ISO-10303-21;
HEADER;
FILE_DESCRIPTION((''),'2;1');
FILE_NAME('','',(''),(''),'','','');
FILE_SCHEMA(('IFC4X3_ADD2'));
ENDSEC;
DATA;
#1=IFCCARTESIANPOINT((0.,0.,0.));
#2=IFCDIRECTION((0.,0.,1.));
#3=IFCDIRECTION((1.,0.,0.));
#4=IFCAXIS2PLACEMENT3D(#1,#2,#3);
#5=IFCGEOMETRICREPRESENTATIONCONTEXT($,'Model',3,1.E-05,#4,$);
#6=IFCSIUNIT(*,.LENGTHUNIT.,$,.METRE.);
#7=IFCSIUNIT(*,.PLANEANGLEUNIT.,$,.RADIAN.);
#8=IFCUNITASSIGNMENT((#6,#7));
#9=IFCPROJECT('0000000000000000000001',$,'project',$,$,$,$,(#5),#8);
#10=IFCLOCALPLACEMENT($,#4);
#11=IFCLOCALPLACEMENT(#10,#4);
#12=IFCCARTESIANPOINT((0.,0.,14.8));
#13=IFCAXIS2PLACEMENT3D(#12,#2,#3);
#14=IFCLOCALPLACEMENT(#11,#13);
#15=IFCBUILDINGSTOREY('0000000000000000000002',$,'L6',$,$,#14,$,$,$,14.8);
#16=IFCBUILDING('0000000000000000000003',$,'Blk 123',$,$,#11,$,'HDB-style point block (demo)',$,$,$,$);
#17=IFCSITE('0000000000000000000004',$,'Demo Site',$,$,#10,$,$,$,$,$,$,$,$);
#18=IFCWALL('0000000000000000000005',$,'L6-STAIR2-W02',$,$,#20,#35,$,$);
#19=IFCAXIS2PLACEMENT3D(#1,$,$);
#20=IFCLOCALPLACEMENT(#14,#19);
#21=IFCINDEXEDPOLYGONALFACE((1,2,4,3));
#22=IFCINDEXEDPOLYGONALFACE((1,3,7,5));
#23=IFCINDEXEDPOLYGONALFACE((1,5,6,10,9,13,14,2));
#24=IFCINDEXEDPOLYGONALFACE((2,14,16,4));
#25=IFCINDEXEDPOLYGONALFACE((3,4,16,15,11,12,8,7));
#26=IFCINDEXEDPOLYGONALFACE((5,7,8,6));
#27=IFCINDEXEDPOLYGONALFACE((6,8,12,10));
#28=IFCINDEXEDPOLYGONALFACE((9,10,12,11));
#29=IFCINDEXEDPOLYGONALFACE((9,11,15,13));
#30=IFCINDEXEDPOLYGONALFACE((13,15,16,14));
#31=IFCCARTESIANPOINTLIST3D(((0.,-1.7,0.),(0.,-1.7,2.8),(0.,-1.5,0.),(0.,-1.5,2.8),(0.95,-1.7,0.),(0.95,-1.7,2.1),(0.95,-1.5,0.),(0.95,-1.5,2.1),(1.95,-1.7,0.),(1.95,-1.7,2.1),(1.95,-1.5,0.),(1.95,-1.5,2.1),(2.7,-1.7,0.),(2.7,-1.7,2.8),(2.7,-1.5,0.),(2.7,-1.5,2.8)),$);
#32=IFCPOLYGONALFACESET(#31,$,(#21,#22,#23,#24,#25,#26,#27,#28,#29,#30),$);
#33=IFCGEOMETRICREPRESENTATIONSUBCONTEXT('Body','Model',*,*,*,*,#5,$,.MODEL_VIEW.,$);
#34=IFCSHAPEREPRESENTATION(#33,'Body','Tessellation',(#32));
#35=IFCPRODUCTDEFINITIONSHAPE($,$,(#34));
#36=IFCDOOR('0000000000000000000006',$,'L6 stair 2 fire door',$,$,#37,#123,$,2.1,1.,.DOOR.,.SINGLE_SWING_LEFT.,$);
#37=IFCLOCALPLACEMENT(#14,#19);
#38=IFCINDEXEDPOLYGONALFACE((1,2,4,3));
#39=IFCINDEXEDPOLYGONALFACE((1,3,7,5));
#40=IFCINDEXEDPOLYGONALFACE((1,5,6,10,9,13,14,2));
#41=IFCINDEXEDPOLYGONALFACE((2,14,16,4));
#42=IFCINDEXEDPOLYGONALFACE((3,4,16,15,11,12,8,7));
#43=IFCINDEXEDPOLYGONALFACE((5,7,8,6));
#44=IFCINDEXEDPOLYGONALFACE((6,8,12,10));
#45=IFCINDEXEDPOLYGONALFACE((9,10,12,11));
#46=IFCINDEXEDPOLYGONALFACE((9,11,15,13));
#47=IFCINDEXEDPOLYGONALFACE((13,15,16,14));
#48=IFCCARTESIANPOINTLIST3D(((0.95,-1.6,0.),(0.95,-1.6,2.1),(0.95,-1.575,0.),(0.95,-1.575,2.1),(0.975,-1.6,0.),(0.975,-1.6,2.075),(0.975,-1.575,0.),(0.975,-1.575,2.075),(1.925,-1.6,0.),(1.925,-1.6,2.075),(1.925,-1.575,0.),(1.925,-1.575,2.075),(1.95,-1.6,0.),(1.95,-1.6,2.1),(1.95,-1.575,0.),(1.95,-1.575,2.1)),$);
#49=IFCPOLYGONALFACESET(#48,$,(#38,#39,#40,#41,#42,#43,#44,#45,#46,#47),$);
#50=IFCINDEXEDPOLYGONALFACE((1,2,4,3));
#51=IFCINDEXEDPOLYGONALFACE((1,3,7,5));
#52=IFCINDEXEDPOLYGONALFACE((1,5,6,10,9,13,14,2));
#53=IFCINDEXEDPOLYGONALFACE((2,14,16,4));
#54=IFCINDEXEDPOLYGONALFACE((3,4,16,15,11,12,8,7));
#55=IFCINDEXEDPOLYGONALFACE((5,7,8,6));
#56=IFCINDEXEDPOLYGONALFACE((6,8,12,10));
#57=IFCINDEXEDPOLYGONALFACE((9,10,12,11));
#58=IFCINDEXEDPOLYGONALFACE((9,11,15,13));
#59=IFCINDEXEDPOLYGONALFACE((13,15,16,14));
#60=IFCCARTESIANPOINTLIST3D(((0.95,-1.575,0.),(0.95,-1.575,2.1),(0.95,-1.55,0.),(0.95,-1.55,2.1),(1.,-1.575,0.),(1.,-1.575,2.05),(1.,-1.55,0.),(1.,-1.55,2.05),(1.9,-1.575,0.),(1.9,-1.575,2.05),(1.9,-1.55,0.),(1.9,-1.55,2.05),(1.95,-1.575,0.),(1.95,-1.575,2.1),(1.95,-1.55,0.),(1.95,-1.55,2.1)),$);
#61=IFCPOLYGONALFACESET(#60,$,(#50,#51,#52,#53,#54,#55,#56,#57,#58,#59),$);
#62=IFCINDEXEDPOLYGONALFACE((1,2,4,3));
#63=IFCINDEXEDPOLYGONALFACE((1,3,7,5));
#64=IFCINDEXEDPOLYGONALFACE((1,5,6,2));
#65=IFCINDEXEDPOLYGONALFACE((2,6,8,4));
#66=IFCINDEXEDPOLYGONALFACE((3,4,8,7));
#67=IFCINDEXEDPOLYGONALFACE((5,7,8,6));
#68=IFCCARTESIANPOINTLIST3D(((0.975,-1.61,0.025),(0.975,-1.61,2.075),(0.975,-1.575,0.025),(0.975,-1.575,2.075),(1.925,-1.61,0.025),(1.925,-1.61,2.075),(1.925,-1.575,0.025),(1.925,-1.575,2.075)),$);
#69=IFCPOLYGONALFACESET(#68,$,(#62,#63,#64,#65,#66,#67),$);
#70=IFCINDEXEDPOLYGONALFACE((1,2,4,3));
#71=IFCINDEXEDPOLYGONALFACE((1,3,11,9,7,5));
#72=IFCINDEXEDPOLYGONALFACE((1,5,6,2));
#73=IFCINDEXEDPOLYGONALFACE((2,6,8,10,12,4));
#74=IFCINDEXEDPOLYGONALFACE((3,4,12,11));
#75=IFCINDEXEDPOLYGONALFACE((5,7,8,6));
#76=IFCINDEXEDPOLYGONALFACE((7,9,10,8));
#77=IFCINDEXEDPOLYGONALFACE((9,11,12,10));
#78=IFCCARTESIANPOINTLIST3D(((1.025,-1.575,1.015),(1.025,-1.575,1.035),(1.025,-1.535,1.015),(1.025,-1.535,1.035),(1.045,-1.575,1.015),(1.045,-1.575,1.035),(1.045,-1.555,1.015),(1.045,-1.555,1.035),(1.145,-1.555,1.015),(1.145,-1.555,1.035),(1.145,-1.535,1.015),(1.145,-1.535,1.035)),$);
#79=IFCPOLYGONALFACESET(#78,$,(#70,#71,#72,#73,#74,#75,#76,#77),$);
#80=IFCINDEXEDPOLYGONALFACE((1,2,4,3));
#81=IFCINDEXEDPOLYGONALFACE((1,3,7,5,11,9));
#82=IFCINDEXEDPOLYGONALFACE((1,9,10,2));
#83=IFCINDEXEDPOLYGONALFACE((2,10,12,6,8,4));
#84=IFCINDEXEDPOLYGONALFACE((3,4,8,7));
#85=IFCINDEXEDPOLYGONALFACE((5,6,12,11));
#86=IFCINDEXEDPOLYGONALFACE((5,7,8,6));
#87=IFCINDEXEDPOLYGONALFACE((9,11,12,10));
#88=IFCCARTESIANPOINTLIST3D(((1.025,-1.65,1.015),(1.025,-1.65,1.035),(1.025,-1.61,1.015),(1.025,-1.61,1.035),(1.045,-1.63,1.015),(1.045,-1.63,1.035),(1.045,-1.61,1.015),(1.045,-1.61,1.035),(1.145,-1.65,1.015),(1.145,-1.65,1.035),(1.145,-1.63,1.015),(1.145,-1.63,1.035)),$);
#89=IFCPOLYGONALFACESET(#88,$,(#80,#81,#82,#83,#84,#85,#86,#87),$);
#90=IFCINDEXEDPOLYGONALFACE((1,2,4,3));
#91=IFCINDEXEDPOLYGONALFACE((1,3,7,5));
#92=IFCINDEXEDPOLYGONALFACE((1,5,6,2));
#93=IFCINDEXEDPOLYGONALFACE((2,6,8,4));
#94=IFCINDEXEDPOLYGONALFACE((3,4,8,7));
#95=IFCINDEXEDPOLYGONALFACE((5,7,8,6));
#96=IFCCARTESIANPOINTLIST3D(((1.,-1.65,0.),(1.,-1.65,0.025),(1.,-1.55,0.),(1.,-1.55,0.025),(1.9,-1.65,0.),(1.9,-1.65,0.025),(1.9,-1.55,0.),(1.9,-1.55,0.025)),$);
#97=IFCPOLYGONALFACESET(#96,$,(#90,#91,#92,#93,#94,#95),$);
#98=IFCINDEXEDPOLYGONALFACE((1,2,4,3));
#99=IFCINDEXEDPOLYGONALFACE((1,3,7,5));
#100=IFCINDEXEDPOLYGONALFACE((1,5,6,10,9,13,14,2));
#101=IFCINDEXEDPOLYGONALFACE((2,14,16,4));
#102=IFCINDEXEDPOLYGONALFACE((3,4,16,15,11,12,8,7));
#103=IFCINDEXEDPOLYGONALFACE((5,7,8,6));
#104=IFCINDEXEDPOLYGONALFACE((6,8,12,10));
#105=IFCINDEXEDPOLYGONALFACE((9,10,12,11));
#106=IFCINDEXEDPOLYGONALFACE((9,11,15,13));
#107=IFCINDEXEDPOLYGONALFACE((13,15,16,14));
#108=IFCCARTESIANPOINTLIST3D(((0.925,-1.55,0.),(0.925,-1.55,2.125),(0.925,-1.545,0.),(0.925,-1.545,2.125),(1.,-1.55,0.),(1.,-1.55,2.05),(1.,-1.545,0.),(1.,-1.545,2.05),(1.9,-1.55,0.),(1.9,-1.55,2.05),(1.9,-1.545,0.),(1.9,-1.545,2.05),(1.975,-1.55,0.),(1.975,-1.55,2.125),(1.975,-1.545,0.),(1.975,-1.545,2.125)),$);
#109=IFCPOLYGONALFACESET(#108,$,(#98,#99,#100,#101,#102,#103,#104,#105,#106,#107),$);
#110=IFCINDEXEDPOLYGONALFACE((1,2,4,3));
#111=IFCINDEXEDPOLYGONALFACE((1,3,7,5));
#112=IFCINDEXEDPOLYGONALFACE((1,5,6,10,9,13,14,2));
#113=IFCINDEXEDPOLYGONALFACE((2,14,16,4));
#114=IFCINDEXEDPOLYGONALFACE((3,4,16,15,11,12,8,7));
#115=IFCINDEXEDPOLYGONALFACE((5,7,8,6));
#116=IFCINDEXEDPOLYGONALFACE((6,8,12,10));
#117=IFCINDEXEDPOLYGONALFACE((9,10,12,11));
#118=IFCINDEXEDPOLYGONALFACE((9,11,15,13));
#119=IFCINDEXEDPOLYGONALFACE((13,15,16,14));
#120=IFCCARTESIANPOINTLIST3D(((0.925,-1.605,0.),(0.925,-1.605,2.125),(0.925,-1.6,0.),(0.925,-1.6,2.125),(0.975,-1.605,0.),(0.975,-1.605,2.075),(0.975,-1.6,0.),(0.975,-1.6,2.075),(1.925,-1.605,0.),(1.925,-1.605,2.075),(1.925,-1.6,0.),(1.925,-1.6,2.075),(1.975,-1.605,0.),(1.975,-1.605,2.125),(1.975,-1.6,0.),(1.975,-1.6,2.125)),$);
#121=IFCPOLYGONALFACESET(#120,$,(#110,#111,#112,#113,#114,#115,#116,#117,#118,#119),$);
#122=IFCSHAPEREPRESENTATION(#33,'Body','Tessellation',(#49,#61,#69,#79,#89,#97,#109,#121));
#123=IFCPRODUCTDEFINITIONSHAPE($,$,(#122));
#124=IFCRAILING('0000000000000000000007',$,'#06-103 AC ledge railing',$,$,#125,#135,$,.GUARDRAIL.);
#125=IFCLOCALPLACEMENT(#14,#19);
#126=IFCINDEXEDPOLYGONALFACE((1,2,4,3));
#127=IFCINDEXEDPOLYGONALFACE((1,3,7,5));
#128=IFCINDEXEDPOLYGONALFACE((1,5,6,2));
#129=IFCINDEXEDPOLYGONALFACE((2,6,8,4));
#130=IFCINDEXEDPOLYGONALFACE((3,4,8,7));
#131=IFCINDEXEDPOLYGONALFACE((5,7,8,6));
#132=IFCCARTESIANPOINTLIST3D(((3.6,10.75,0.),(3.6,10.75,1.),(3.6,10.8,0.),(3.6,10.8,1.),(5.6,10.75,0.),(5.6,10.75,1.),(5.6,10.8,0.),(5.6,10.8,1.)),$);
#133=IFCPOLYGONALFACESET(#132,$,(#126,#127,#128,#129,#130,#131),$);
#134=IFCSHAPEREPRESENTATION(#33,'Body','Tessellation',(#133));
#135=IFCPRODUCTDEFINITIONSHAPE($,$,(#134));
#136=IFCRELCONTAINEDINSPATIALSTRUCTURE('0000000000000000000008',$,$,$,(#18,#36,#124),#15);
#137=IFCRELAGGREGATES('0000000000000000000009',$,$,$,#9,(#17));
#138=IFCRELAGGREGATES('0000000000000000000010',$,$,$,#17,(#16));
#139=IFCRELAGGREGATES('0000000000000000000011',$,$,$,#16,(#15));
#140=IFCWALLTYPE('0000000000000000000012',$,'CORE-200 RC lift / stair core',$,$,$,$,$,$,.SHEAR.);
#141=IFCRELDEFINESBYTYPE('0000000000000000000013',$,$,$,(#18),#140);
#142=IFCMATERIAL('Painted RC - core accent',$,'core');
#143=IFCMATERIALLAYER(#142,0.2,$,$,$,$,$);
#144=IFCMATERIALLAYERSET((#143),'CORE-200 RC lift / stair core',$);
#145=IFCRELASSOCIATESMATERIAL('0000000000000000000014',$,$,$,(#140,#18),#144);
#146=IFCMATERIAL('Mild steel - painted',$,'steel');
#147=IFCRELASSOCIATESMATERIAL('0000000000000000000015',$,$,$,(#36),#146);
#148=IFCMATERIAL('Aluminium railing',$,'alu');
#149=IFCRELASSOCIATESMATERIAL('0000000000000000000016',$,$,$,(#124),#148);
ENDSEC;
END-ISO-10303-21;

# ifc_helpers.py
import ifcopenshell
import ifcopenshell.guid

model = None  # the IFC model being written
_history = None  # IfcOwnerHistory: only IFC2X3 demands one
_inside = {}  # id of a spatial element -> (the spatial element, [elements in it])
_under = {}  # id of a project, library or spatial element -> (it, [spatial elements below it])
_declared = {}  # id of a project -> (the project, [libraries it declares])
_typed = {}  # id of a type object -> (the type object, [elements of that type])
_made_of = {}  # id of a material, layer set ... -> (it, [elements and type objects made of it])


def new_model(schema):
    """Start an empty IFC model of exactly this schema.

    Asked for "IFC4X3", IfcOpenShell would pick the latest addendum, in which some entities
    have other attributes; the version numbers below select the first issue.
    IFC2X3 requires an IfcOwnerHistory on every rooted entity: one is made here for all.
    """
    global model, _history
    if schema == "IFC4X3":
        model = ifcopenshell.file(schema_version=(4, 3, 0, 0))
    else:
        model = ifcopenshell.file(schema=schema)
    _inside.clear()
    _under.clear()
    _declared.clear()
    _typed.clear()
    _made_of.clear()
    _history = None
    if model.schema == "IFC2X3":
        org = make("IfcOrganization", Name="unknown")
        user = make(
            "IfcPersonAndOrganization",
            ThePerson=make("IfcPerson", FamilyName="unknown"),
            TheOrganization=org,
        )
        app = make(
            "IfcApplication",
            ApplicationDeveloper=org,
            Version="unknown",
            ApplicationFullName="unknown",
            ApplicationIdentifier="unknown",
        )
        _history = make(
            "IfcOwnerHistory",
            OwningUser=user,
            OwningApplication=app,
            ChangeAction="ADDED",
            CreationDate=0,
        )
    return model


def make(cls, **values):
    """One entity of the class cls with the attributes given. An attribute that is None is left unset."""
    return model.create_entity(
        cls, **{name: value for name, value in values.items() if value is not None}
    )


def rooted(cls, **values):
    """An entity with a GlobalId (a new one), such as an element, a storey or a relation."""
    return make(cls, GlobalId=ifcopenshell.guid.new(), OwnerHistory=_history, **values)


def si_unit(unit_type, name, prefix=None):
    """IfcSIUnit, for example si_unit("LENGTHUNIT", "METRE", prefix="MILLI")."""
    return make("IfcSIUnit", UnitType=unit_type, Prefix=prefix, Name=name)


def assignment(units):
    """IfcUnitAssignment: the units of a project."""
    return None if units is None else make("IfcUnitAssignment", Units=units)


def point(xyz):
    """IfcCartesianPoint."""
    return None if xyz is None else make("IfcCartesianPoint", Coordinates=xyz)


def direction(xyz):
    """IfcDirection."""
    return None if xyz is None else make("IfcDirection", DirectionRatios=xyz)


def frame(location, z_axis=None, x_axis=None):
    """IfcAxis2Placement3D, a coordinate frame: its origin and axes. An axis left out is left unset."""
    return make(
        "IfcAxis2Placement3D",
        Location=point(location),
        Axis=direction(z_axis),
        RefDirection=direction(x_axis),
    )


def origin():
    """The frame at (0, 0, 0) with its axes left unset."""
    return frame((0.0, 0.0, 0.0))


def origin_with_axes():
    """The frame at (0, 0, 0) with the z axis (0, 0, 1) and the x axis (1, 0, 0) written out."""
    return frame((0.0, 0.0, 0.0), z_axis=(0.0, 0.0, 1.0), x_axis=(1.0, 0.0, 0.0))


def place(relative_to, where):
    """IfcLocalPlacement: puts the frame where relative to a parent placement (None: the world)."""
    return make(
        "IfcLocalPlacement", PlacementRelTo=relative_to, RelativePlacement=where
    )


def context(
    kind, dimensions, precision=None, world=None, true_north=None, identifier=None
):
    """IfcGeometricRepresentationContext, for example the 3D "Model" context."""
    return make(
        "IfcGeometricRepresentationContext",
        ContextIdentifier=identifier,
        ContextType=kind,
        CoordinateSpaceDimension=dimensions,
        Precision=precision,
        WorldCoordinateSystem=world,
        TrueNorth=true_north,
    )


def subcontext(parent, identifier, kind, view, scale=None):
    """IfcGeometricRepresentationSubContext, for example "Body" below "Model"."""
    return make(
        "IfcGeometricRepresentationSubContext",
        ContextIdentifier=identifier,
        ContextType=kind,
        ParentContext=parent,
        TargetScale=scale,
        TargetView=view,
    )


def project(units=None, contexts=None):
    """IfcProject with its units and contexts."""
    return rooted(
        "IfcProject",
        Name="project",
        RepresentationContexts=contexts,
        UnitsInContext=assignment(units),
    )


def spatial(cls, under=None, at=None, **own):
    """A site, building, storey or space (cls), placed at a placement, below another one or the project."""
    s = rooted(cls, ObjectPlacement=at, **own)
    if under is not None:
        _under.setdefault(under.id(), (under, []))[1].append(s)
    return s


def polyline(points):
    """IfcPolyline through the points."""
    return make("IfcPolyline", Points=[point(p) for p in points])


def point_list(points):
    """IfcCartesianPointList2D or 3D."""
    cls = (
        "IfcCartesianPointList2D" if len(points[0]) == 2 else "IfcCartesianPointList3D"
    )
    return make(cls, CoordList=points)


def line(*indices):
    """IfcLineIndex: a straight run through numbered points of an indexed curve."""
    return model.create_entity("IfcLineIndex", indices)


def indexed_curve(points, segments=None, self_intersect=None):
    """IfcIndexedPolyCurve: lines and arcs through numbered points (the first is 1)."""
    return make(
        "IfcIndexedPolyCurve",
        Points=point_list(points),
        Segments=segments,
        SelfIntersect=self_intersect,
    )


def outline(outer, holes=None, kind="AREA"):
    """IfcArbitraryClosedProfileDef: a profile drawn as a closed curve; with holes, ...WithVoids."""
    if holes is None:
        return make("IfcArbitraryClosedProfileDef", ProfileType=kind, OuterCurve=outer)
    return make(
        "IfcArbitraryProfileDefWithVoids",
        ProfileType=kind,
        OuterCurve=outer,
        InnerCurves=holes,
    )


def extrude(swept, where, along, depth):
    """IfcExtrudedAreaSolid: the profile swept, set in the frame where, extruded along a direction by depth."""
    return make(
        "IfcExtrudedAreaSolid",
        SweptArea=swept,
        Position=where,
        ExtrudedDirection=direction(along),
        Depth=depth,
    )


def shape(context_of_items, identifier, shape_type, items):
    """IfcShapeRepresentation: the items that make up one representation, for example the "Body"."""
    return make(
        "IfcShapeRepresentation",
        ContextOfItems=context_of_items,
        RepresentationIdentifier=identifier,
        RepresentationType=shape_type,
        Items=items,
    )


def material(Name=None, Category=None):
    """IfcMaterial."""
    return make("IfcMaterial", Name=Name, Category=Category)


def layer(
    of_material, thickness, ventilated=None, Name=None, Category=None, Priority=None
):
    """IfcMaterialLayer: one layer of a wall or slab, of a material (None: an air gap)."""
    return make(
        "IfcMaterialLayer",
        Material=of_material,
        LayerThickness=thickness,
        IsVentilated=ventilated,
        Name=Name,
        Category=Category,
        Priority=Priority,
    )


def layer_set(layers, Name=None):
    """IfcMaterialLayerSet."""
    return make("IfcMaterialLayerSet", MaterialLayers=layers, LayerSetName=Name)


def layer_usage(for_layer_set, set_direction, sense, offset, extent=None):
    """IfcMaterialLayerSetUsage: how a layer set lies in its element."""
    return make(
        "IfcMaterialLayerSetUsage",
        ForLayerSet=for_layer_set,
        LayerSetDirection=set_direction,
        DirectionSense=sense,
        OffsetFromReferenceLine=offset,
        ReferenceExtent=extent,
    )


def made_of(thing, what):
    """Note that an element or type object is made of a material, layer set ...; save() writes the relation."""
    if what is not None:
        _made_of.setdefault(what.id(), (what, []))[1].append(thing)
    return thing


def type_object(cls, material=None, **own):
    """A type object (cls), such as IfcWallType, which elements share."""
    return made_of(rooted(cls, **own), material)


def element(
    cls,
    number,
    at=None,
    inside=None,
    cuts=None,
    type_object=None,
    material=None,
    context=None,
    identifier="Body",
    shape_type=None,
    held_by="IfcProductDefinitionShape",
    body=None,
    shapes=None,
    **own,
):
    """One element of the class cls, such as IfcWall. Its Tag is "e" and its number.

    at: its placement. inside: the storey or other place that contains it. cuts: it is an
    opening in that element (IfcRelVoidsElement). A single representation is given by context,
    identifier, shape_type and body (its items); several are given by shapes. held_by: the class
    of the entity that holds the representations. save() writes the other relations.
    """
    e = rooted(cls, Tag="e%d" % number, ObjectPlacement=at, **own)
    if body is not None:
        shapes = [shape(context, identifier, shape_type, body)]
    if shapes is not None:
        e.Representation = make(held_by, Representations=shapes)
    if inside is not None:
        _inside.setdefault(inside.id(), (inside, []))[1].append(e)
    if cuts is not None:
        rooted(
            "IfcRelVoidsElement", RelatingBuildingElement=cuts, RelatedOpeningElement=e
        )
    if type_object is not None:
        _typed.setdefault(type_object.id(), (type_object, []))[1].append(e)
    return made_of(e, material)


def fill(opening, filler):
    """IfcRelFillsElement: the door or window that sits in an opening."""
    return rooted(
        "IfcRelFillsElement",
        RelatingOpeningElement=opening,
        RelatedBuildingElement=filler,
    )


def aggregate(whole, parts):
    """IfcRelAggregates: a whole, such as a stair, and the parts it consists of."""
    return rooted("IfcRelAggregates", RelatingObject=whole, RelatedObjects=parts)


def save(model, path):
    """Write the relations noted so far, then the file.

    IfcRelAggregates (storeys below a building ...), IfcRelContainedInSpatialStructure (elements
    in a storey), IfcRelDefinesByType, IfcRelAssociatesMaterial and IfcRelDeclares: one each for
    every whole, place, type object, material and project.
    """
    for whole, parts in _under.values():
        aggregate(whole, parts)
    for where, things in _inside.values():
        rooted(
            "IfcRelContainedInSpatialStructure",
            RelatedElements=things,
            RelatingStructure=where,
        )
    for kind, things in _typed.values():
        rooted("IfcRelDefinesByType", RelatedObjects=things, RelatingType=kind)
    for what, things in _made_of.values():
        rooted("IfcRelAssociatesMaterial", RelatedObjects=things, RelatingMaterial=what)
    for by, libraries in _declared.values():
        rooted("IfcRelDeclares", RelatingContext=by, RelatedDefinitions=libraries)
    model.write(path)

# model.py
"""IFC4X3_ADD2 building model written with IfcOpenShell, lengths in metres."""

from ifc_helpers import new_model, si_unit, frame, origin, origin_with_axes, place, context, subcontext, project, spatial, polyline, line, indexed_curve, outline, extrude, material, layer, layer_set, layer_usage, type_object, element, fill, save


model = new_model("IFC4X3_ADD2")

# Units and contexts
model_context = context("Model", 3, precision=1e-05, world=origin_with_axes())
body_context = subcontext(model_context, "Body", "Model", "MODEL_VIEW")
ifc_project = project(units=[si_unit("LENGTHUNIT", "METRE"), si_unit("PLANEANGLEUNIT", "RADIAN")], contexts=[model_context])

# Site, building, storey
site_placement = place(None, origin_with_axes())
site = spatial("IfcSite", under=ifc_project, at=site_placement, Name="Demo Site")
building_placement = place(site_placement, origin_with_axes())
building = spatial("IfcBuilding", under=site, at=building_placement, Name="Blk 123", LongName="HDB-style point block (demo)")
storey_placement = place(building_placement, frame((0.0, 0.0, 14.8), z_axis=(0.0, 0.0, 1.0), x_axis=(1.0, 0.0, 0.0)))
storey = spatial("IfcBuildingStorey", under=building, at=storey_placement, Name="L6", Elevation=14.8)

# Shared definitions
ifc_material_1 = material(Name="Painted RC - core accent", Category="core")
ifc_layer_1 = layer(ifc_material_1, 0.2)
ifc_layer_set_1 = layer_set([ifc_layer_1], Name="CORE-200 RC lift / stair core")
ifc_layer_usage_1 = layer_usage(ifc_layer_set_1, "AXIS2", "POSITIVE", 0.0)
wall_type_1 = type_object("IfcWallType", Name="CORE-200 RC lift / stair core", PredefinedType="SHEAR", material=ifc_layer_set_1)

# Wall, opening, door
wall_1_placement = place(storey_placement, frame((2.7, -1.5, 0.0), z_axis=(0.0, 0.0, 1.0), x_axis=(-1.0, 0.0, 0.0)))
wall_1 = element("IfcWall", 1, at=wall_1_placement, inside=storey, type_object=wall_type_1, material=ifc_layer_usage_1, Name="L6-STAIR2-W02", context=body_context, shape_type="SweptSolid", body=[
    extrude(outline(indexed_curve([(0.0, 0.0), (0.0, 0.2), (2.7, 0.2), (2.7, 0.0), (0.0, 0.0)], self_intersect=False)), origin_with_axes(), (0.0, 0.0, 1.0), 2.8),
])
opening_1_placement = place(wall_1_placement, frame((0.75, -0.1, 0.0), z_axis=(0.0, 0.0, 1.0), x_axis=(1.0, 0.0, 0.0)))
opening_1 = element("IfcOpeningElement", 2, at=opening_1_placement, cuts=wall_1, context=body_context, shape_type="SweptSolid", body=[
    extrude(outline(indexed_curve([(0.0, 0.0), (0.0, 0.4), (1.0, 0.4), (1.0, 0.0), (0.0, 0.0)], self_intersect=False)), origin_with_axes(), (0.0, 0.0, 1.0), 2.1),
])
ifc_material_2 = material(Name="Mild steel - painted", Category="steel")
door_1_placement = place(opening_1_placement, frame((0.0, 0.15, 0.0), z_axis=(0.0, 0.0, 1.0), x_axis=(1.0, 0.0, 0.0)))
door_1 = element("IfcDoor", 3, at=door_1_placement, inside=storey, material=ifc_material_2, Name="L6 stair 2 fire door", OperationType="SINGLE_SWING_LEFT", OverallHeight=2.1, OverallWidth=1.0, PredefinedType="DOOR", context=body_context, shape_type="SweptSolid", body=[
    extrude(outline(indexed_curve([(0.0, 0.0), (0.0, 2.1), (1.0, 2.1), (1.0, 0.0), (0.975, 0.0), (0.975, 2.075), (0.025, 2.075), (0.025, 0.0)], segments=[line(1, 2, 3, 4, 5, 6, 7, 8, 1)])), frame((0.0, 0.025, 0.0), z_axis=(0.0, -1.0, 0.0), x_axis=(1.0, 0.0, 0.0)), (0.0, 0.0, -1.0), 0.025),
    extrude(outline(indexed_curve([(0.0, 0.0), (0.0, 2.1), (1.0, 2.1), (1.0, 0.0), (0.95, 0.0), (0.95, 2.05), (0.05, 2.05), (0.05, 0.0)], segments=[line(1, 2, 3, 4, 5, 6, 7, 8, 1)])), frame((0.0, 0.0, 0.0), z_axis=(0.0, -1.0, 0.0), x_axis=(1.0, 0.0, 0.0)), (0.0, 0.0, -1.0), 0.025),
    extrude(outline(indexed_curve([(0.0, 0.0), (0.95, 0.0), (0.95, 0.035), (0.0, 0.035)], segments=[line(1, 2, 3, 4, 1)])), frame((0.025, 0.025, 0.025), z_axis=(0.0, 0.0, 1.0), x_axis=(1.0, 0.0, 0.0)), (0.0, 0.0, 1.0), 2.05),
    extrude(outline(indexed_curve([(0.0, 0.0), (0.0, -0.04), (-0.12, -0.04), (-0.12, -0.02), (-0.02, -0.02), (-0.02, 0.0)], segments=[line(1, 2, 3, 4, 5, 6, 1)])), frame((0.925, 0.025, 1.015), z_axis=(0.0, 0.0, 1.0), x_axis=(1.0, 0.0, 0.0)), (0.0, 0.0, 1.0), 0.02),
    extrude(outline(indexed_curve([(0.0, 0.0), (0.0, 0.04), (-0.12, 0.04), (-0.12, 0.02), (-0.02, 0.02), (-0.02, 0.0)], segments=[line(1, 2, 3, 4, 5, 6, 1)])), frame((0.925, 0.06, 1.015), z_axis=(0.0, 0.0, 1.0), x_axis=(1.0, 0.0, 0.0)), (0.0, 0.0, 1.0), 0.02),
    extrude(outline(indexed_curve([(0.0, 0.0), (0.9, 0.0), (0.9, 0.1), (0.0, 0.1)], segments=[line(1, 2, 3, 4, 1)])), frame((0.05, 0.0, 0.0), z_axis=(0.0, 0.0, 1.0), x_axis=(1.0, 0.0, 0.0)), (0.0, 0.0, 1.0), 0.025),
    extrude(outline(indexed_curve([(0.0, 0.0), (0.0, 2.125), (1.05, 2.125), (1.05, 0.0), (0.975, 0.0), (0.975, 2.05), (0.075, 2.05), (0.075, 0.0)], segments=[line(1, 2, 3, 4, 5, 6, 7, 8, 1)])), frame((-0.025, -0.005, 0.0), z_axis=(0.0, -1.0, 0.0), x_axis=(1.0, 0.0, 0.0)), (0.0, 0.0, -1.0), 0.005),
    extrude(outline(indexed_curve([(0.0, 0.0), (0.0, 2.125), (1.05, 2.125), (1.05, 0.0), (1.0, 0.0), (1.0, 2.075), (0.05, 2.075), (0.05, 0.0)], segments=[line(1, 2, 3, 4, 5, 6, 7, 8, 1)])), frame((-0.025, 0.05, 0.0), z_axis=(0.0, -1.0, 0.0), x_axis=(1.0, 0.0, 0.0)), (0.0, 0.0, -1.0), 0.005),
])
fill(opening_1, door_1)

# Railing
ifc_material_3 = material(Name="Aluminium railing", Category="alu")
railing_placement = place(storey_placement, frame((4.6, 10.775, 0.0), z_axis=(0.0, 0.0, 1.0), x_axis=(1.0, 0.0, 0.0)))
element("IfcRailing", 4, at=railing_placement, inside=storey, material=ifc_material_3, Name="#06-103 AC ledge railing", PredefinedType="GUARDRAIL", context=body_context, shape_type="SweptSolid", body=[
    extrude(outline(polyline([(1.0, -0.025), (1.0, 0.025), (-1.0, 0.025), (-1.0, -0.025), (1.0, -0.025)])), origin(), (0.0, 0.0, 1.0), 1.0),
])

save(model, "model.ifc")
